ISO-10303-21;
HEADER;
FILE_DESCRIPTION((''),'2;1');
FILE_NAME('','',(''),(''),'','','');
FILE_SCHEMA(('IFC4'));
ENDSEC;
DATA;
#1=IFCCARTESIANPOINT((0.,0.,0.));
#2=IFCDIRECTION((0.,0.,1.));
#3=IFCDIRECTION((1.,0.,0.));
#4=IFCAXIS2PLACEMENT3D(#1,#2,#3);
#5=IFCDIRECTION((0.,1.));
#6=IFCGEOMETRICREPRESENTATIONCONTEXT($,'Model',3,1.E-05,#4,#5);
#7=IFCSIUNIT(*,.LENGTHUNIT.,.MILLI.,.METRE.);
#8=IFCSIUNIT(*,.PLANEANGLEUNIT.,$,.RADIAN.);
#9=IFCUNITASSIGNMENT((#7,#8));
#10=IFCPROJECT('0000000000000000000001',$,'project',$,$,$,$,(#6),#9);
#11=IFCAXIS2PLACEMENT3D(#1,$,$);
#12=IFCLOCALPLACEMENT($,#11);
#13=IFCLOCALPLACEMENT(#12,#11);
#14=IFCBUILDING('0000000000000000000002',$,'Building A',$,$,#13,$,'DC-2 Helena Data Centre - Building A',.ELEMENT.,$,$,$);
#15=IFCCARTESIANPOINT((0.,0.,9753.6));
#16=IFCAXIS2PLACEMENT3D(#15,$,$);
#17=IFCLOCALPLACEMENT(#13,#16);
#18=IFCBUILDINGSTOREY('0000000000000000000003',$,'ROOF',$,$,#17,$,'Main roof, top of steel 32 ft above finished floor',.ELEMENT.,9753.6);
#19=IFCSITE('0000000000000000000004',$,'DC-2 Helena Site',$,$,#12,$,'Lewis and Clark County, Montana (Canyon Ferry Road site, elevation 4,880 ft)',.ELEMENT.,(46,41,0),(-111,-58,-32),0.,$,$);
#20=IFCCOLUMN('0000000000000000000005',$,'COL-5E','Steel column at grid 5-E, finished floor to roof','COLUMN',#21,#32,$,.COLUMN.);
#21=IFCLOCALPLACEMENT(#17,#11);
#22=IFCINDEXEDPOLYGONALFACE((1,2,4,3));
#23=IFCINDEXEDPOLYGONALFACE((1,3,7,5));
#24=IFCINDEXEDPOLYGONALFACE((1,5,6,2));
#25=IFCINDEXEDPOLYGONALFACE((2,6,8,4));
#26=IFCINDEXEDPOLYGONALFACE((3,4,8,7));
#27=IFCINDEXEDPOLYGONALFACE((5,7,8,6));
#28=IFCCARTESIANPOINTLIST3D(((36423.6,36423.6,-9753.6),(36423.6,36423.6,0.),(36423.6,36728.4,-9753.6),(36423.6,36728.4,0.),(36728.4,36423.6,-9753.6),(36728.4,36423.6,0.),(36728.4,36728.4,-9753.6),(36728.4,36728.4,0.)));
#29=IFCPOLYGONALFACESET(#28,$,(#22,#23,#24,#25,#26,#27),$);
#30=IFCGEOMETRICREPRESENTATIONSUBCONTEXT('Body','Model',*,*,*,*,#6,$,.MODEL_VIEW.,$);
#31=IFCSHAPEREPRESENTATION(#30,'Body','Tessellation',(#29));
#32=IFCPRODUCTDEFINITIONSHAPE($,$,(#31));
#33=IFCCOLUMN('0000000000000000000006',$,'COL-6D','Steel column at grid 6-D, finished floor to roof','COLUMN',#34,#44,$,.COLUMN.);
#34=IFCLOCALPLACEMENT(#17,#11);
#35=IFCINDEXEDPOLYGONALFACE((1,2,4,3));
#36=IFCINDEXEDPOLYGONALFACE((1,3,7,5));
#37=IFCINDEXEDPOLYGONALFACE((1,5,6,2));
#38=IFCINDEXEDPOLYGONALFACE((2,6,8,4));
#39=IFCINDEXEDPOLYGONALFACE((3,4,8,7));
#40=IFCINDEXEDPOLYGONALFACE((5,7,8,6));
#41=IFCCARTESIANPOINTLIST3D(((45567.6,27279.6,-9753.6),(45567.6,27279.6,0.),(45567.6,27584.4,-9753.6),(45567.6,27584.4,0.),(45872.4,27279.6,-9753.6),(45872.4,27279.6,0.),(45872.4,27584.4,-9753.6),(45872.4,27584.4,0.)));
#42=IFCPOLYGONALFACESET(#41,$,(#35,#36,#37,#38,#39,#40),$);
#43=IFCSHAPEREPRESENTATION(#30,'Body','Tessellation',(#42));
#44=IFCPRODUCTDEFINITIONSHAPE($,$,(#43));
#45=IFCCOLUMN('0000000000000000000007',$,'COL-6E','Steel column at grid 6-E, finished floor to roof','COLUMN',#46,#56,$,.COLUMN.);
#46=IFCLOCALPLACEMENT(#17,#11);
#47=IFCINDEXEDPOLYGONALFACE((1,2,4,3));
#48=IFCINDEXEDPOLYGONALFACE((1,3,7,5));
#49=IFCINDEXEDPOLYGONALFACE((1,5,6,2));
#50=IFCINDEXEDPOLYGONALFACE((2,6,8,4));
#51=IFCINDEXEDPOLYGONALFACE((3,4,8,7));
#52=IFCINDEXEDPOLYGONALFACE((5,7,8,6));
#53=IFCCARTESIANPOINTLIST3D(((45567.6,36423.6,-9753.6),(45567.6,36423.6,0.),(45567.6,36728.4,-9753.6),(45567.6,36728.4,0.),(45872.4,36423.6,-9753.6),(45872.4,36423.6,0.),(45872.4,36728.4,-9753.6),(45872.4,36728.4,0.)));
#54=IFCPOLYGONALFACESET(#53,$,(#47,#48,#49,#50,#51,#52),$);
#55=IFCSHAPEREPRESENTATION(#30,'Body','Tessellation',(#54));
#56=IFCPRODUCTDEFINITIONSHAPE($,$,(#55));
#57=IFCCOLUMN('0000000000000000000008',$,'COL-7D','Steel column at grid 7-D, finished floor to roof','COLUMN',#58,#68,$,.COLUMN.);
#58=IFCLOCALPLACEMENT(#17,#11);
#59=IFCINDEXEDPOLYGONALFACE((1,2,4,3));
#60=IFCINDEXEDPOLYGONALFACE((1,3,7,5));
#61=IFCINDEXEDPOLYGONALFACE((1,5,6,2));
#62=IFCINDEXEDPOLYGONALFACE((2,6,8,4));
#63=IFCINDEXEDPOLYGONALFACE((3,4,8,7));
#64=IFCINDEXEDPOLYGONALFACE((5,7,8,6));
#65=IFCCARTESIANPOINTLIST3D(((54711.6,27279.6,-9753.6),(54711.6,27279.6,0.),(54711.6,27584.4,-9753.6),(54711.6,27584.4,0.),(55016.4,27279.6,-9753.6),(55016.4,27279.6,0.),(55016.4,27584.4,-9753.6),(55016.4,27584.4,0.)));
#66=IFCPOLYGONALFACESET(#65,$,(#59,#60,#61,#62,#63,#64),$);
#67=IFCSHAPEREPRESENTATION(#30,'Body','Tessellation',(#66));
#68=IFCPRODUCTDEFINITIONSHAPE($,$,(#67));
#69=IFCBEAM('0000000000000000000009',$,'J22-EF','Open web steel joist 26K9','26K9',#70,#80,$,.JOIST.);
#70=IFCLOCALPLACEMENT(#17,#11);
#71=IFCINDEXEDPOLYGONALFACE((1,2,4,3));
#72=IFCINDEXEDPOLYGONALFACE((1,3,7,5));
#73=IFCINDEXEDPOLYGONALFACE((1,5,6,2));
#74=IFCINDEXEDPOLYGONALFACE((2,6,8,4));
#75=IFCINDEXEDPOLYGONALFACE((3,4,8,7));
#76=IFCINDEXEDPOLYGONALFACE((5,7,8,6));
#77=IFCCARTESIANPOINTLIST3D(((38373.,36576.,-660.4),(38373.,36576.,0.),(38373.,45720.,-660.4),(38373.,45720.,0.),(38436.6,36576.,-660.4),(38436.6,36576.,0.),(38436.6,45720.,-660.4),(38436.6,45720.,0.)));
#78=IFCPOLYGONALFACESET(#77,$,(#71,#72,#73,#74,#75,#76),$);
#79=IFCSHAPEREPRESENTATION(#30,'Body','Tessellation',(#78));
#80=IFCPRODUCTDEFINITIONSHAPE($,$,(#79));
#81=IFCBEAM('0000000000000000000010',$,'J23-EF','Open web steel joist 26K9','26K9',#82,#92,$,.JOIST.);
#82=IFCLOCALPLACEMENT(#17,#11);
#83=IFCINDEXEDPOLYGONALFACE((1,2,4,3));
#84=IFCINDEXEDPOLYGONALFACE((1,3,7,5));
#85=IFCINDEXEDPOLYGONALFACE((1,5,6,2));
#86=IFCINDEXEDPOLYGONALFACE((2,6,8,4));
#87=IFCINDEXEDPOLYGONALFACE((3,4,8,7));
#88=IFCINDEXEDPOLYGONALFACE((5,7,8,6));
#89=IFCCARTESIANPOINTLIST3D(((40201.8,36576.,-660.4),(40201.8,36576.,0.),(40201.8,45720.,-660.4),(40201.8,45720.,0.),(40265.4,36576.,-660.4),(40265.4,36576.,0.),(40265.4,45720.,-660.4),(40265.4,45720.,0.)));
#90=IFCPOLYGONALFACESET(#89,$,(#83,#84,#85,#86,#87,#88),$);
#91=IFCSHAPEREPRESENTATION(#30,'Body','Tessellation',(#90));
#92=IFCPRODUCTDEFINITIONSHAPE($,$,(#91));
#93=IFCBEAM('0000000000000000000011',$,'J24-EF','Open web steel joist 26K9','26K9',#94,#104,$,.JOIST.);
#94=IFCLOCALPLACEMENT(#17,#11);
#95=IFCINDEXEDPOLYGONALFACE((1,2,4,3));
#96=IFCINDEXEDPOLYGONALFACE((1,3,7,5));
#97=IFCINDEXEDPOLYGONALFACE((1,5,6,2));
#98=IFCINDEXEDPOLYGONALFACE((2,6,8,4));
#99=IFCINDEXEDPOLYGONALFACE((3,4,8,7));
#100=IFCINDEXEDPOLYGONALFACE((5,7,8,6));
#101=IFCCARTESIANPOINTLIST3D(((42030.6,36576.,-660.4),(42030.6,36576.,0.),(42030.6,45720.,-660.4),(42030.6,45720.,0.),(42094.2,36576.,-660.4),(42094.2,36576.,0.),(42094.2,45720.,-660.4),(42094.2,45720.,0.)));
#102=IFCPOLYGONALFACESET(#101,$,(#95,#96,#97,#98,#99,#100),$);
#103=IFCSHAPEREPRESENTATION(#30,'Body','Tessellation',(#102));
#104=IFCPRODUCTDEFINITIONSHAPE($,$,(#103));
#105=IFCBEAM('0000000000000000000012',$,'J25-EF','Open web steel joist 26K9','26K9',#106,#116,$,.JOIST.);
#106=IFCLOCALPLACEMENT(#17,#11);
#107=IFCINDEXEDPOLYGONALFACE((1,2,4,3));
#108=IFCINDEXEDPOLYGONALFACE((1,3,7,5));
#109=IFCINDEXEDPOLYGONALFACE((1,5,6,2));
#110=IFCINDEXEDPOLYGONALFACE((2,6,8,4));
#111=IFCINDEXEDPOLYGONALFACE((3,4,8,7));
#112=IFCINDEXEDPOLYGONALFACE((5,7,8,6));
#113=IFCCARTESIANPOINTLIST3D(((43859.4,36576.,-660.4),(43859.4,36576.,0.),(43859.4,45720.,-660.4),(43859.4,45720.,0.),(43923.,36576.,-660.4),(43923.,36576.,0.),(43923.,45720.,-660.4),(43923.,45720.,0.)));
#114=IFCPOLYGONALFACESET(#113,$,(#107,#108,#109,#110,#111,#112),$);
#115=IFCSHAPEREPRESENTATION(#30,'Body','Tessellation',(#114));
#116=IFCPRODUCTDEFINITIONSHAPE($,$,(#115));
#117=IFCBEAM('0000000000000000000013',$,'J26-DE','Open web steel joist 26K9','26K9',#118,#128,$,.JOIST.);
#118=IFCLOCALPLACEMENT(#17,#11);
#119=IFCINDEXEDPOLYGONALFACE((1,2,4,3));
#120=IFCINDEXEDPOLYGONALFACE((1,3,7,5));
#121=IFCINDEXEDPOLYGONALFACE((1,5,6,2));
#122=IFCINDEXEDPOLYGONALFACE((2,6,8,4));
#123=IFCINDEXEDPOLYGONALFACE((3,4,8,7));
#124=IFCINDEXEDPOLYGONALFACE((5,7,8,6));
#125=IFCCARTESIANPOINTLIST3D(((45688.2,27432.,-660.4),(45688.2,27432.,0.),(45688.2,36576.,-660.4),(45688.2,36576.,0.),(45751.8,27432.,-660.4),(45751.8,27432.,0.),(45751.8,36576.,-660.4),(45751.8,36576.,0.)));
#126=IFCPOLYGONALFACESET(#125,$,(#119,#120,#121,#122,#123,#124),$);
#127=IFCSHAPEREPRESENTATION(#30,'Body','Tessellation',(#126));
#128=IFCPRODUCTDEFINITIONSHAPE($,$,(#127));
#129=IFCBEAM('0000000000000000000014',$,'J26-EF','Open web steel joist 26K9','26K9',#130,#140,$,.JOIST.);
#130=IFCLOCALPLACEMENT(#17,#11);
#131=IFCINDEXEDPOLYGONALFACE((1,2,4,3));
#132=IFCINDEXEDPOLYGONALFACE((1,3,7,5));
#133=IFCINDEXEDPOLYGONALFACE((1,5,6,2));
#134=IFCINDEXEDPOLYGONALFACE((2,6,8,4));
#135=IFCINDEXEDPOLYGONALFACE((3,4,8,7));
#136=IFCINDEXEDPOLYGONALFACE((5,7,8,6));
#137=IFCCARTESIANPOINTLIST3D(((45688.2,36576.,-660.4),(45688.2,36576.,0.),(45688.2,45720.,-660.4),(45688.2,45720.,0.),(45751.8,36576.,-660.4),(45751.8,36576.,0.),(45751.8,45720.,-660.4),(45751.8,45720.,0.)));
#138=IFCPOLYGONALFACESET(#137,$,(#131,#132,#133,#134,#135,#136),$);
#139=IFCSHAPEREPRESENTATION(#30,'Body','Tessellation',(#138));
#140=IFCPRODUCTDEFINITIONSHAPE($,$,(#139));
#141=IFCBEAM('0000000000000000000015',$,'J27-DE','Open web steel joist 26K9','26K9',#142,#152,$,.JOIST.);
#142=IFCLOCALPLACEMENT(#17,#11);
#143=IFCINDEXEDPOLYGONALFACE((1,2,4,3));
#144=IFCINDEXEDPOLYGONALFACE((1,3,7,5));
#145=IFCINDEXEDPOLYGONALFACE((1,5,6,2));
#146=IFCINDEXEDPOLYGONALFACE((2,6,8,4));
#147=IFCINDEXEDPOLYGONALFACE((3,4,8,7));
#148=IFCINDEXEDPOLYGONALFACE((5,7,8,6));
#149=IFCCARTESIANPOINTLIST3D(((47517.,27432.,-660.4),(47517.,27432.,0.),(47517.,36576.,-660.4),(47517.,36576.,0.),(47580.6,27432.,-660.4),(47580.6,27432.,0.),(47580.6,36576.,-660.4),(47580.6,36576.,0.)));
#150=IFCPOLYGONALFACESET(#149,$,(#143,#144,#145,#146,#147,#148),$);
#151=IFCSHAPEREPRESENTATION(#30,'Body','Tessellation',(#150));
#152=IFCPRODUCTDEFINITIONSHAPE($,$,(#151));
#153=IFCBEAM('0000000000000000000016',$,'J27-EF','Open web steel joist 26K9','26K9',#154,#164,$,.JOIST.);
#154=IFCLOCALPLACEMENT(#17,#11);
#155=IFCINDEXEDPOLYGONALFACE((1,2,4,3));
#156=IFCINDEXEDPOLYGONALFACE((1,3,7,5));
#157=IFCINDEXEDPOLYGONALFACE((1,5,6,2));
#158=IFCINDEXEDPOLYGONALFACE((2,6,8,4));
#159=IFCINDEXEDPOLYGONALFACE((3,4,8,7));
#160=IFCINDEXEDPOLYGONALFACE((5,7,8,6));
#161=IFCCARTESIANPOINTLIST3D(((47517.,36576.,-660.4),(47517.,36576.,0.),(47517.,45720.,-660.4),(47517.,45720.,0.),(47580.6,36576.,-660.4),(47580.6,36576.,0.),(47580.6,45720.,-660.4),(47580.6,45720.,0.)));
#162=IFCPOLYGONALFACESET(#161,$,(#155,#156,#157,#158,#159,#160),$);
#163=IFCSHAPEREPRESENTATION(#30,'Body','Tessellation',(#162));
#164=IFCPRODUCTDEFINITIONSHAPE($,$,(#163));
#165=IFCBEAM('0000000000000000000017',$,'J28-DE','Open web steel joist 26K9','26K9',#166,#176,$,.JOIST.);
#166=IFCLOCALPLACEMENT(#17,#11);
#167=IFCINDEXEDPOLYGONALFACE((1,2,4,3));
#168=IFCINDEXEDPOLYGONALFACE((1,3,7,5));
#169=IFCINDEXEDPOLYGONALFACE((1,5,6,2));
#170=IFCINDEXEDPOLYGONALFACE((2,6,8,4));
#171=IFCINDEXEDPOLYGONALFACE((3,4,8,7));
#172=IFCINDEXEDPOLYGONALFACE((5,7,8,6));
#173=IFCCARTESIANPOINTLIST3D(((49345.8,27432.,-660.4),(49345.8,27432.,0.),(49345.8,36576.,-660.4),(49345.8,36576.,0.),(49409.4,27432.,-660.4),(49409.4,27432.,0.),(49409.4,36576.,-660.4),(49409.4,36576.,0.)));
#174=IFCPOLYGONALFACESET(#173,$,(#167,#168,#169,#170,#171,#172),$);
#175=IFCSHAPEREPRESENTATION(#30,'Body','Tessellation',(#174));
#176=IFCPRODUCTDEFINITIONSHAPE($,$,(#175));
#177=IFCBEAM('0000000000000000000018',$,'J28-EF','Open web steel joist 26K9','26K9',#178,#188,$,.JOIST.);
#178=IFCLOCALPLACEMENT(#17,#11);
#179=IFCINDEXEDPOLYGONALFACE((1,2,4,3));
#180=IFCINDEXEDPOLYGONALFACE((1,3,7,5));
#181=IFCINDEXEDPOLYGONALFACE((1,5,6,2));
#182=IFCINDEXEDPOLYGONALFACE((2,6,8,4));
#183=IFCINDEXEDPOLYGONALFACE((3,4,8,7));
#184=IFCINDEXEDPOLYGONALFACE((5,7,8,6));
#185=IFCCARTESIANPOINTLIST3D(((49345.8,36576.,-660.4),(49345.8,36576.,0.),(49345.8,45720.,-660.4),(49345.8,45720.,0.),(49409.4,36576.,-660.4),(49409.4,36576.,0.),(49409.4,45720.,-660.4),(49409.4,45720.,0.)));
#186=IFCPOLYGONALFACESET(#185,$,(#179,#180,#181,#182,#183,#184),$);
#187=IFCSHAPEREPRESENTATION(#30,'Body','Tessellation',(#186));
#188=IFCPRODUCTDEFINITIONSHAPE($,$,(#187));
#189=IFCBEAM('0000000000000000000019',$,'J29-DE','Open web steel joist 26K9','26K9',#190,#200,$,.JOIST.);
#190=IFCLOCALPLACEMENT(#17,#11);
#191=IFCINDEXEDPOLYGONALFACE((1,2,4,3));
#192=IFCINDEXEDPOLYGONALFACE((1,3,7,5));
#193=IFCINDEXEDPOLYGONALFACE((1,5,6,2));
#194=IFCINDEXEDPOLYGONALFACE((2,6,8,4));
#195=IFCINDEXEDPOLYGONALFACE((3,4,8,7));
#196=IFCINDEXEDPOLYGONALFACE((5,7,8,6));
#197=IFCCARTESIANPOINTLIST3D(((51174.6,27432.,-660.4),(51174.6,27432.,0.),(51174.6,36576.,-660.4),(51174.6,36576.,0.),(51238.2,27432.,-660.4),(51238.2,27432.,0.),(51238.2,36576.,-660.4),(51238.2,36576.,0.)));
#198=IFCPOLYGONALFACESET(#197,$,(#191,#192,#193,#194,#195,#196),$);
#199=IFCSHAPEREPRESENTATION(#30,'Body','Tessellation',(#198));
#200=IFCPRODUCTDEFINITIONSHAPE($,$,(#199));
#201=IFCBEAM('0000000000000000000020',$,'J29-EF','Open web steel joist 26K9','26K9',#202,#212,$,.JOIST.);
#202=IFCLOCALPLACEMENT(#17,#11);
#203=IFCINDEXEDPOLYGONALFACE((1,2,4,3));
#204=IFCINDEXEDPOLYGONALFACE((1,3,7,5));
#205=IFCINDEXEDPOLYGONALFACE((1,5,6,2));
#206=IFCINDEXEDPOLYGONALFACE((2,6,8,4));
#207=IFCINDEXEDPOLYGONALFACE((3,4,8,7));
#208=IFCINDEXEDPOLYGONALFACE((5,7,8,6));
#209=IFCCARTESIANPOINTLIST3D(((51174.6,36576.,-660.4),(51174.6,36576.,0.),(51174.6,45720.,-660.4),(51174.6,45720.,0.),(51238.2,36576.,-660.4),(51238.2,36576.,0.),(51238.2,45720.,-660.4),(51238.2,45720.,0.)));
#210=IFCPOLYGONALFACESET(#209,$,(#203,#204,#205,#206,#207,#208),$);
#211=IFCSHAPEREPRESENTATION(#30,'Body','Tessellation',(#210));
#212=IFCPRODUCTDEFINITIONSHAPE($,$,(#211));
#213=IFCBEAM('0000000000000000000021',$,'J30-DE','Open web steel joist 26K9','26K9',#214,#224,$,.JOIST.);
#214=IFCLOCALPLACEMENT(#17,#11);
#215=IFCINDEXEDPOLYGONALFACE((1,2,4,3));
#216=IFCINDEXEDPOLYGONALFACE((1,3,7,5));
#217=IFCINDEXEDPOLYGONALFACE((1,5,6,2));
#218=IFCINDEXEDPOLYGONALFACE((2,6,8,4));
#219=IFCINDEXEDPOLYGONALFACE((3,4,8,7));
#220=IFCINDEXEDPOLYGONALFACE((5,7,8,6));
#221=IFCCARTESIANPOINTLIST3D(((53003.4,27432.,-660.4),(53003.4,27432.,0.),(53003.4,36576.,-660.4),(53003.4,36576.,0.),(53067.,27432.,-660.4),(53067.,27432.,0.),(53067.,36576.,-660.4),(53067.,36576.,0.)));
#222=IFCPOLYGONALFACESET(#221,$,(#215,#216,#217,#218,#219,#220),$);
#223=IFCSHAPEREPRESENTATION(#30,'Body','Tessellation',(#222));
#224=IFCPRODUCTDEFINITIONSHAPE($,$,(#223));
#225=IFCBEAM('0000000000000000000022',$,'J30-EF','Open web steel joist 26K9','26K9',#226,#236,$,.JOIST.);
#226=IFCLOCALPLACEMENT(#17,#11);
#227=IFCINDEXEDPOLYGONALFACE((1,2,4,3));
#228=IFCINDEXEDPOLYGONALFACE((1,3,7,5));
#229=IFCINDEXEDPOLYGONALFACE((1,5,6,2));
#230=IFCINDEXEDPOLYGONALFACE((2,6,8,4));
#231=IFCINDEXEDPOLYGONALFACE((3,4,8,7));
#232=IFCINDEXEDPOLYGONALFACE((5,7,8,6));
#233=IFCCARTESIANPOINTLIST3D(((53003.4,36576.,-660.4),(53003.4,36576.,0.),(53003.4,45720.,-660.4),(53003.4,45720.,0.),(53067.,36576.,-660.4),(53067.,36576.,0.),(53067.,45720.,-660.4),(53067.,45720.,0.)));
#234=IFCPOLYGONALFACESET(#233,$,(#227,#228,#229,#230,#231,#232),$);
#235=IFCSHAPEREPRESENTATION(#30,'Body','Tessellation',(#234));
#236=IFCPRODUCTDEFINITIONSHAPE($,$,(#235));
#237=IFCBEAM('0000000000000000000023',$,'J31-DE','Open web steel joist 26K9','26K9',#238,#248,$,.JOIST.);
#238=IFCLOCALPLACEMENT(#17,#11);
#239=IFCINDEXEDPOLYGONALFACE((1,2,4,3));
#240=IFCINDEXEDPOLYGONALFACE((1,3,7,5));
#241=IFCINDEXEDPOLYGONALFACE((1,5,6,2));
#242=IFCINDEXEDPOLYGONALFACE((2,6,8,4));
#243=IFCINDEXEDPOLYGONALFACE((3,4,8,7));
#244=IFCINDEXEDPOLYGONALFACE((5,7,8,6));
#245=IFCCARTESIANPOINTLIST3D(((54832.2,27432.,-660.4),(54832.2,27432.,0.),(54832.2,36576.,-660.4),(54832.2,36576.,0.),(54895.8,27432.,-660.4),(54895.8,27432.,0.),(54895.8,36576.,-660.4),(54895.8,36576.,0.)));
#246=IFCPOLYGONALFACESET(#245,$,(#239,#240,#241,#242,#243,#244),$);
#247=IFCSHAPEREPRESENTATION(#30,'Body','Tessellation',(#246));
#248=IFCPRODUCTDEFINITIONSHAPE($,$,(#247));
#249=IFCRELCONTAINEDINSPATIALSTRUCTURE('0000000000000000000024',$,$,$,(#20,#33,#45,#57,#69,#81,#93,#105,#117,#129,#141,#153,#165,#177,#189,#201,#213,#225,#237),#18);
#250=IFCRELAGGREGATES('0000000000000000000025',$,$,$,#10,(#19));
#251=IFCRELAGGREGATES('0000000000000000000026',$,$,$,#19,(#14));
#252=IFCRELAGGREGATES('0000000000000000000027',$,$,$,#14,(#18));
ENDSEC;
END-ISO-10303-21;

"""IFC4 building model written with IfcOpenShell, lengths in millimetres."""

from ifc_helpers import new_model, si_unit, direction, frame, origin, origin_with_axes, origin_2d, place, context, subcontext, project, spatial, rectangle, extrude, element, save


model = new_model("IFC4")

# Units and contexts
model_context = context("Model", 3, precision=1e-05, world=origin_with_axes(), true_north=direction((0.0, 1.0)))
body_context = subcontext(model_context, "Body", "Model", "MODEL_VIEW")
ifc_project = project(units=[si_unit("LENGTHUNIT", "METRE", prefix="MILLI"), si_unit("PLANEANGLEUNIT", "RADIAN")], contexts=[model_context])

# Site, building, storey
site_placement = place(None, origin())
site = spatial("IfcSite", under=ifc_project, at=site_placement, Name="DC-2 Helena Site", LongName="Lewis and Clark County, Montana (Canyon Ferry Road site, elevation 4,880 ft)", CompositionType="ELEMENT", RefLatitude=(46, 41, 0), RefLongitude=(-111, -58, -32), RefElevation=0.0)
building_placement = place(site_placement, origin())
building = spatial("IfcBuilding", under=site, at=building_placement, Name="Building A", LongName="DC-2 Helena Data Centre - Building A", CompositionType="ELEMENT")
storey_placement = place(building_placement, frame((0.0, 0.0, 9753.6)))
storey = spatial("IfcBuildingStorey", under=building, at=storey_placement, Name="ROOF", LongName="Main roof, top of steel 32 ft above finished floor", CompositionType="ELEMENT", Elevation=9753.6)

# Columns
for number, where, name, description in (
    (1, (36576.0, 36576.0, -9753.6), "COL-5E", "Steel column at grid 5-E, finished floor to roof"),
    (2, (45720.0, 27432.0, -9753.6), "COL-6D", "Steel column at grid 6-D, finished floor to roof"),
    (3, (45720.0, 36576.0, -9753.6), "COL-6E", "Steel column at grid 6-E, finished floor to roof"),
    (4, (54864.0, 27432.0, -9753.6), "COL-7D", "Steel column at grid 7-D, finished floor to roof"),
):
    element("IfcColumn", number, at=place(storey_placement, frame(where)), inside=storey, Name=name, Description=description, ObjectType="COLUMN", PredefinedType="COLUMN", context=body_context, shape_type="SweptSolid", body=[
        extrude(rectangle(XDim=304.8, YDim=304.8, at=origin_2d()), origin(), (0.0, 0.0, 1.0), 9753.6),
    ])

# Beams
for number, where, name in (
    (5, (38404.8, 36576.0, 0.0), "J22-EF"),
    (6, (40233.6, 36576.0, 0.0), "J23-EF"),
    (7, (42062.4, 36576.0, 0.0), "J24-EF"),
    (8, (43891.2, 36576.0, 0.0), "J25-EF"),
):
    element("IfcBeam", number, at=place(storey_placement, frame(where)), inside=storey, Name=name, Description="Open web steel joist 26K9", ObjectType="26K9", PredefinedType="JOIST", context=body_context, shape_type="SweptSolid", body=[
        extrude(rectangle(XDim=63.5, YDim=660.4, at=origin_2d()), frame((0.0, 0.0, -330.2), z_axis=(0.0, 1.0, 0.0), x_axis=(1.0, 0.0, 0.0)), (0.0, 0.0, 1.0), 9144.0),
    ])
placement_1 = place(storey_placement, frame((45720.0, 27432.0, 0.0)))
element("IfcBeam", 9, at=placement_1, inside=storey, Name="J26-DE", Description="Open web steel joist 26K9", ObjectType="26K9", PredefinedType="JOIST", context=body_context, shape_type="SweptSolid", body=[
    extrude(rectangle(XDim=63.5, YDim=660.4, at=origin_2d()), frame((0.0, 0.0, -330.2), z_axis=(0.0, 1.0, 0.0), x_axis=(1.0, 0.0, 0.0)), (0.0, 0.0, 1.0), 9144.0),
])
placement_2 = place(storey_placement, frame((45720.0, 36576.0, 0.0)))
element("IfcBeam", 10, at=placement_2, inside=storey, Name="J26-EF", Description="Open web steel joist 26K9", ObjectType="26K9", PredefinedType="JOIST", context=body_context, shape_type="SweptSolid", body=[
    extrude(rectangle(XDim=63.5, YDim=660.4, at=origin_2d()), frame((0.0, 0.0, -330.2), z_axis=(0.0, 1.0, 0.0), x_axis=(1.0, 0.0, 0.0)), (0.0, 0.0, 1.0), 9144.0),
])
for number, where, name in (
    (11, (47548.8, 27432.0, 0.0), "J27-DE"),
    (12, (47548.8, 36576.0, 0.0), "J27-EF"),
    (13, (49377.6, 27432.0, 0.0), "J28-DE"),
    (14, (49377.6, 36576.0, 0.0), "J28-EF"),
    (15, (51206.4, 27432.0, 0.0), "J29-DE"),
    (16, (51206.4, 36576.0, 0.0), "J29-EF"),
    (17, (53035.2, 27432.0, 0.0), "J30-DE"),
    (18, (53035.2, 36576.0, 0.0), "J30-EF"),
):
    element("IfcBeam", number, at=place(storey_placement, frame(where)), inside=storey, Name=name, Description="Open web steel joist 26K9", ObjectType="26K9", PredefinedType="JOIST", context=body_context, shape_type="SweptSolid", body=[
        extrude(rectangle(XDim=63.5, YDim=660.4, at=origin_2d()), frame((0.0, 0.0, -330.2), z_axis=(0.0, 1.0, 0.0), x_axis=(1.0, 0.0, 0.0)), (0.0, 0.0, 1.0), 9144.0),
    ])
placement_3 = place(storey_placement, frame((54864.0, 27432.0, 0.0)))
element("IfcBeam", 19, at=placement_3, inside=storey, Name="J31-DE", Description="Open web steel joist 26K9", ObjectType="26K9", PredefinedType="JOIST", context=body_context, shape_type="SweptSolid", body=[
    extrude(rectangle(XDim=63.5, YDim=660.4, at=origin_2d()), frame((0.0, 0.0, -330.2), z_axis=(0.0, 1.0, 0.0), x_axis=(1.0, 0.0, 0.0)), (0.0, 0.0, 1.0), 9144.0),
])

save(model, "model.ifc")
